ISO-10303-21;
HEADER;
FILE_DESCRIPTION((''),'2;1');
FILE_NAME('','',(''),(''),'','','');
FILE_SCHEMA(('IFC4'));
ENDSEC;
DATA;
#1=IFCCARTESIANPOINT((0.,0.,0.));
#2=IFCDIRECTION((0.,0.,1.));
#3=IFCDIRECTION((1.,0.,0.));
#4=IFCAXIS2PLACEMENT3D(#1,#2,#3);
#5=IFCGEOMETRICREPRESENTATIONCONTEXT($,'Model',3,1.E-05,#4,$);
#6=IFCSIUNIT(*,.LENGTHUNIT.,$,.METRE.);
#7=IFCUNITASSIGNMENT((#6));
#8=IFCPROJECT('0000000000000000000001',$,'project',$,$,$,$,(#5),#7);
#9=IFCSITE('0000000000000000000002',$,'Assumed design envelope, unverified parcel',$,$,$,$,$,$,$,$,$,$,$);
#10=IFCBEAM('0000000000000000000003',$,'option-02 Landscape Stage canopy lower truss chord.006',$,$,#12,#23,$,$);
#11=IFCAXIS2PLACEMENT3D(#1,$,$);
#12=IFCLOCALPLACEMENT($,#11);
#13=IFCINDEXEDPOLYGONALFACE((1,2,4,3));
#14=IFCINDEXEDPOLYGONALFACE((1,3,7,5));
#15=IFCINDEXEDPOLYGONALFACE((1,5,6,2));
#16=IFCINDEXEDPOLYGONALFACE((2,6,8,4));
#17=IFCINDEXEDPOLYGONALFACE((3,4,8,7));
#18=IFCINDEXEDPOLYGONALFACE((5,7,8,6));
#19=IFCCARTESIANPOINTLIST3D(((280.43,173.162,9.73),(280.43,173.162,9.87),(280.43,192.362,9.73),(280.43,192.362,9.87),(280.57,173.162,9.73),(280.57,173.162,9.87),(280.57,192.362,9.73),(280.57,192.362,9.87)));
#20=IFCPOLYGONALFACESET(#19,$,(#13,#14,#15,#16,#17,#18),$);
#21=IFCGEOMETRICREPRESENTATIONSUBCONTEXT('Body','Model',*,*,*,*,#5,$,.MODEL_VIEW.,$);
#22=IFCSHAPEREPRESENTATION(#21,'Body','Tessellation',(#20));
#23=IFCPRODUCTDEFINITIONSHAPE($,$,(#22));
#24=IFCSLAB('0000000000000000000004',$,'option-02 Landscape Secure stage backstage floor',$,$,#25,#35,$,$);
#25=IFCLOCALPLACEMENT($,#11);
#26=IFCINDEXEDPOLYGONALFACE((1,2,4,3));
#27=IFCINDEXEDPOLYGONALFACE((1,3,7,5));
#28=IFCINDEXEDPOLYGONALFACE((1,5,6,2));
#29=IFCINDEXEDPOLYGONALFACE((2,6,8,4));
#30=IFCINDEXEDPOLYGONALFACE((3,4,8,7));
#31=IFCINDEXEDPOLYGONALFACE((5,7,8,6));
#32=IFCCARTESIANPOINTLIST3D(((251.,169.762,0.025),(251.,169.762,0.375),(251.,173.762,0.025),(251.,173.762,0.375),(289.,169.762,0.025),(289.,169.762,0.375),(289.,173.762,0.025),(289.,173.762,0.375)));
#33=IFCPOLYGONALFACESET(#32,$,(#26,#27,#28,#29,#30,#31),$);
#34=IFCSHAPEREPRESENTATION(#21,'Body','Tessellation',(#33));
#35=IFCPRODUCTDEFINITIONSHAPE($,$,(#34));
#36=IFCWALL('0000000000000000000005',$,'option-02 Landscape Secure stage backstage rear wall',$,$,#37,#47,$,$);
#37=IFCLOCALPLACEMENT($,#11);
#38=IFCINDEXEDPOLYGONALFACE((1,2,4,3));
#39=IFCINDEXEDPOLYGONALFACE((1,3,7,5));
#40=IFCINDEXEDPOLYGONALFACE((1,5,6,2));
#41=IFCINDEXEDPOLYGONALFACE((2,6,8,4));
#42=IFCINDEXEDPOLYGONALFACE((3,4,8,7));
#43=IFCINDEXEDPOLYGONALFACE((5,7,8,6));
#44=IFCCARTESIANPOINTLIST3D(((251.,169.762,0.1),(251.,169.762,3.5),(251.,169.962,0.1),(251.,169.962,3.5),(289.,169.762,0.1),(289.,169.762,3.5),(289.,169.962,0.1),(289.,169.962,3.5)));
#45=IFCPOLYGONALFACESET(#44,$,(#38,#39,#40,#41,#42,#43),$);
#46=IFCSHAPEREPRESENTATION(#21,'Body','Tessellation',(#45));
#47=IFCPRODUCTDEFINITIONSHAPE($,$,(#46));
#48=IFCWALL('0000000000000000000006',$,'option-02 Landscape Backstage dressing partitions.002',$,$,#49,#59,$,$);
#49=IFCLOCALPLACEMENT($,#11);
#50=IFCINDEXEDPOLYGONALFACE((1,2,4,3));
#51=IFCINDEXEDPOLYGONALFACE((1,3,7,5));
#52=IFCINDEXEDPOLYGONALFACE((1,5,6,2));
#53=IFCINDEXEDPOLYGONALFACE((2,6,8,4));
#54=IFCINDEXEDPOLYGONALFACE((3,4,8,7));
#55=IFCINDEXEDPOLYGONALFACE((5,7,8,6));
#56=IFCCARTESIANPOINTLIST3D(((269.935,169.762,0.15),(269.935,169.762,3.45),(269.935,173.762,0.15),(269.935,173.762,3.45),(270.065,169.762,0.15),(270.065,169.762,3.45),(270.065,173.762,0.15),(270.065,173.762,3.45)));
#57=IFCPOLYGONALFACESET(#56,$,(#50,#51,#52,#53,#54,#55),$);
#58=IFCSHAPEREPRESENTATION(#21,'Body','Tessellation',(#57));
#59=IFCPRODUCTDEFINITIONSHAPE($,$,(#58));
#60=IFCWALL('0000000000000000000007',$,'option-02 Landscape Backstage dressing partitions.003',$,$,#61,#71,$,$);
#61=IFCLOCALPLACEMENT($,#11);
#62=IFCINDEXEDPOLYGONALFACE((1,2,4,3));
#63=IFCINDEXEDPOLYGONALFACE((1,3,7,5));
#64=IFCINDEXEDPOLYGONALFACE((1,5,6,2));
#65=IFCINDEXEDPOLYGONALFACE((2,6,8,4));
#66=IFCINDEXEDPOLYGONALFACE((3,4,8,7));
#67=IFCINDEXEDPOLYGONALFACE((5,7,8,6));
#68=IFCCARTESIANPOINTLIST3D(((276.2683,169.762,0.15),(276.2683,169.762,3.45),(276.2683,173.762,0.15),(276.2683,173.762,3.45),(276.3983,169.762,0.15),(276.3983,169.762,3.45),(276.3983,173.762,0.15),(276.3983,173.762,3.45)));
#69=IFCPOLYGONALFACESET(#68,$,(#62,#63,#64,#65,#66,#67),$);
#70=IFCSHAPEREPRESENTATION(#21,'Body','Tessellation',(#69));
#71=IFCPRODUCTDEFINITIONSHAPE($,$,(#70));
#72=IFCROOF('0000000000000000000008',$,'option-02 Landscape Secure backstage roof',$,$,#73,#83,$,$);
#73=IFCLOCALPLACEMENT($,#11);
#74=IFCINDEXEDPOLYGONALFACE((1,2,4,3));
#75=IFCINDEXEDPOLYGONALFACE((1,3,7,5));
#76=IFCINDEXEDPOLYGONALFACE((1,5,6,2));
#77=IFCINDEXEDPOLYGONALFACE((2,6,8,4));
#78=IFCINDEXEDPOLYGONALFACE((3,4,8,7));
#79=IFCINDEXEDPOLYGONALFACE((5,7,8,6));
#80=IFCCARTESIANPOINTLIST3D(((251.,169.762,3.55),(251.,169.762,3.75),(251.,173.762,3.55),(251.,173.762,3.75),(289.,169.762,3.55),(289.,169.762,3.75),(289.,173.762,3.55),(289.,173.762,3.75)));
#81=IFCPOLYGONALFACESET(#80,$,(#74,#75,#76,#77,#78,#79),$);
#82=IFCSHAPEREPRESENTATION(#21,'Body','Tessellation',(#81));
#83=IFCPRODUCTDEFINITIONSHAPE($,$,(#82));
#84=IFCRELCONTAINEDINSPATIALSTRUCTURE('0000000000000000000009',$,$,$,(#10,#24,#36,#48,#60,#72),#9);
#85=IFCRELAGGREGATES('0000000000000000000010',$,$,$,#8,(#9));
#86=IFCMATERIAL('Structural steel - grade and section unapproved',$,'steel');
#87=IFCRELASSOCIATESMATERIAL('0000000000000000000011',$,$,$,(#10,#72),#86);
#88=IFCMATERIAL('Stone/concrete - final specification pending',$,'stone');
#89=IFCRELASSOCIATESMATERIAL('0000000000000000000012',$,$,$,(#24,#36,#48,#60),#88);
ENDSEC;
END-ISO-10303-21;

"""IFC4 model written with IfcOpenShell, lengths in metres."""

from ifc_helpers import new_model, si_unit, frame, origin_with_axes, place, context, subcontext, project, spatial, rectangle, extrude, material, element, save


model = new_model("IFC4")

# Units and contexts
model_context = context("Model", 3, precision=1e-05, world=origin_with_axes())
body_context = subcontext(model_context, "Body", "Model", "MODEL_VIEW")
ifc_project = project(units=[si_unit("LENGTHUNIT", "METRE")], contexts=[model_context])

# Site
site = spatial("IfcSite", under=ifc_project, Name="Assumed design envelope, unverified parcel")

# Beam
ifc_material_1 = material(Name="Structural steel - grade and section unapproved", Category="steel")
beam_1_placement = place(None, frame((280.5, 173.162, 9.8), z_axis=(0.0, 1.0, 0.0), x_axis=(-1.0, 0.0, 0.0)))
element("IfcBeam", 1, at=beam_1_placement, inside=site, material=ifc_material_1, Name="option-02 Landscape Stage canopy lower truss chord.006", context=body_context, shape_type="SweptSolid", body=[
    extrude(rectangle(XDim=0.14, YDim=0.14), origin_with_axes(), (0.0, 0.0, 1.0), 19.2),
])

# Slab
ifc_material_2 = material(Name="Stone/concrete - final specification pending", Category="stone")
slab_placement = place(None, frame((270.0, 171.762, 0.025), z_axis=(0.0, 0.0, 1.0), x_axis=(1.0, 0.0, 0.0)))
element("IfcSlab", 2, at=slab_placement, inside=site, material=ifc_material_2, Name="option-02 Landscape Secure stage backstage floor", context=body_context, shape_type="SweptSolid", body=[
    extrude(rectangle(XDim=38.0, YDim=4.0), origin_with_axes(), (0.0, 0.0, 1.0), 0.35),
])

# Walls
wall_placement = place(None, frame((270.0, 169.862, 0.1), z_axis=(0.0, 0.0, 1.0), x_axis=(1.0, 0.0, 0.0)))
element("IfcWall", 3, at=wall_placement, inside=site, material=ifc_material_2, Name="option-02 Landscape Secure stage backstage rear wall", context=body_context, shape_type="SweptSolid", body=[
    extrude(rectangle(XDim=38.0, YDim=0.2), origin_with_axes(), (0.0, 0.0, 1.0), 3.4),
])
for number, where, z_axis, x_axis, name in (
    (4, (270.0, 171.762, 0.15), (0.0, 0.0, 1.0), (1.0, 0.0, 0.0), "option-02 Landscape Backstage dressing partitions.002"),
    (5, (276.3333, 171.762, 0.15), (0.0, 0.0, 1.0), (1.0, 0.0, 0.0), "option-02 Landscape Backstage dressing partitions.003"),
):
    element("IfcWall", number, at=place(None, frame(where, z_axis=z_axis, x_axis=x_axis)), inside=site, material=ifc_material_2, Name=name, context=body_context, shape_type="SweptSolid", body=[
        extrude(rectangle(XDim=0.13, YDim=4.0), origin_with_axes(), (0.0, 0.0, 1.0), 3.3),
    ])

# Roof
roof_placement = place(None, frame((270.0, 171.762, 3.55), z_axis=(0.0, 0.0, 1.0), x_axis=(1.0, 0.0, 0.0)))
element("IfcRoof", 6, at=roof_placement, inside=site, material=ifc_material_1, Name="option-02 Landscape Secure backstage roof", context=body_context, shape_type="SweptSolid", body=[
    extrude(rectangle(XDim=38.0, YDim=4.0), origin_with_axes(), (0.0, 0.0, 1.0), 0.2),
])

save(model, "model.ifc")
